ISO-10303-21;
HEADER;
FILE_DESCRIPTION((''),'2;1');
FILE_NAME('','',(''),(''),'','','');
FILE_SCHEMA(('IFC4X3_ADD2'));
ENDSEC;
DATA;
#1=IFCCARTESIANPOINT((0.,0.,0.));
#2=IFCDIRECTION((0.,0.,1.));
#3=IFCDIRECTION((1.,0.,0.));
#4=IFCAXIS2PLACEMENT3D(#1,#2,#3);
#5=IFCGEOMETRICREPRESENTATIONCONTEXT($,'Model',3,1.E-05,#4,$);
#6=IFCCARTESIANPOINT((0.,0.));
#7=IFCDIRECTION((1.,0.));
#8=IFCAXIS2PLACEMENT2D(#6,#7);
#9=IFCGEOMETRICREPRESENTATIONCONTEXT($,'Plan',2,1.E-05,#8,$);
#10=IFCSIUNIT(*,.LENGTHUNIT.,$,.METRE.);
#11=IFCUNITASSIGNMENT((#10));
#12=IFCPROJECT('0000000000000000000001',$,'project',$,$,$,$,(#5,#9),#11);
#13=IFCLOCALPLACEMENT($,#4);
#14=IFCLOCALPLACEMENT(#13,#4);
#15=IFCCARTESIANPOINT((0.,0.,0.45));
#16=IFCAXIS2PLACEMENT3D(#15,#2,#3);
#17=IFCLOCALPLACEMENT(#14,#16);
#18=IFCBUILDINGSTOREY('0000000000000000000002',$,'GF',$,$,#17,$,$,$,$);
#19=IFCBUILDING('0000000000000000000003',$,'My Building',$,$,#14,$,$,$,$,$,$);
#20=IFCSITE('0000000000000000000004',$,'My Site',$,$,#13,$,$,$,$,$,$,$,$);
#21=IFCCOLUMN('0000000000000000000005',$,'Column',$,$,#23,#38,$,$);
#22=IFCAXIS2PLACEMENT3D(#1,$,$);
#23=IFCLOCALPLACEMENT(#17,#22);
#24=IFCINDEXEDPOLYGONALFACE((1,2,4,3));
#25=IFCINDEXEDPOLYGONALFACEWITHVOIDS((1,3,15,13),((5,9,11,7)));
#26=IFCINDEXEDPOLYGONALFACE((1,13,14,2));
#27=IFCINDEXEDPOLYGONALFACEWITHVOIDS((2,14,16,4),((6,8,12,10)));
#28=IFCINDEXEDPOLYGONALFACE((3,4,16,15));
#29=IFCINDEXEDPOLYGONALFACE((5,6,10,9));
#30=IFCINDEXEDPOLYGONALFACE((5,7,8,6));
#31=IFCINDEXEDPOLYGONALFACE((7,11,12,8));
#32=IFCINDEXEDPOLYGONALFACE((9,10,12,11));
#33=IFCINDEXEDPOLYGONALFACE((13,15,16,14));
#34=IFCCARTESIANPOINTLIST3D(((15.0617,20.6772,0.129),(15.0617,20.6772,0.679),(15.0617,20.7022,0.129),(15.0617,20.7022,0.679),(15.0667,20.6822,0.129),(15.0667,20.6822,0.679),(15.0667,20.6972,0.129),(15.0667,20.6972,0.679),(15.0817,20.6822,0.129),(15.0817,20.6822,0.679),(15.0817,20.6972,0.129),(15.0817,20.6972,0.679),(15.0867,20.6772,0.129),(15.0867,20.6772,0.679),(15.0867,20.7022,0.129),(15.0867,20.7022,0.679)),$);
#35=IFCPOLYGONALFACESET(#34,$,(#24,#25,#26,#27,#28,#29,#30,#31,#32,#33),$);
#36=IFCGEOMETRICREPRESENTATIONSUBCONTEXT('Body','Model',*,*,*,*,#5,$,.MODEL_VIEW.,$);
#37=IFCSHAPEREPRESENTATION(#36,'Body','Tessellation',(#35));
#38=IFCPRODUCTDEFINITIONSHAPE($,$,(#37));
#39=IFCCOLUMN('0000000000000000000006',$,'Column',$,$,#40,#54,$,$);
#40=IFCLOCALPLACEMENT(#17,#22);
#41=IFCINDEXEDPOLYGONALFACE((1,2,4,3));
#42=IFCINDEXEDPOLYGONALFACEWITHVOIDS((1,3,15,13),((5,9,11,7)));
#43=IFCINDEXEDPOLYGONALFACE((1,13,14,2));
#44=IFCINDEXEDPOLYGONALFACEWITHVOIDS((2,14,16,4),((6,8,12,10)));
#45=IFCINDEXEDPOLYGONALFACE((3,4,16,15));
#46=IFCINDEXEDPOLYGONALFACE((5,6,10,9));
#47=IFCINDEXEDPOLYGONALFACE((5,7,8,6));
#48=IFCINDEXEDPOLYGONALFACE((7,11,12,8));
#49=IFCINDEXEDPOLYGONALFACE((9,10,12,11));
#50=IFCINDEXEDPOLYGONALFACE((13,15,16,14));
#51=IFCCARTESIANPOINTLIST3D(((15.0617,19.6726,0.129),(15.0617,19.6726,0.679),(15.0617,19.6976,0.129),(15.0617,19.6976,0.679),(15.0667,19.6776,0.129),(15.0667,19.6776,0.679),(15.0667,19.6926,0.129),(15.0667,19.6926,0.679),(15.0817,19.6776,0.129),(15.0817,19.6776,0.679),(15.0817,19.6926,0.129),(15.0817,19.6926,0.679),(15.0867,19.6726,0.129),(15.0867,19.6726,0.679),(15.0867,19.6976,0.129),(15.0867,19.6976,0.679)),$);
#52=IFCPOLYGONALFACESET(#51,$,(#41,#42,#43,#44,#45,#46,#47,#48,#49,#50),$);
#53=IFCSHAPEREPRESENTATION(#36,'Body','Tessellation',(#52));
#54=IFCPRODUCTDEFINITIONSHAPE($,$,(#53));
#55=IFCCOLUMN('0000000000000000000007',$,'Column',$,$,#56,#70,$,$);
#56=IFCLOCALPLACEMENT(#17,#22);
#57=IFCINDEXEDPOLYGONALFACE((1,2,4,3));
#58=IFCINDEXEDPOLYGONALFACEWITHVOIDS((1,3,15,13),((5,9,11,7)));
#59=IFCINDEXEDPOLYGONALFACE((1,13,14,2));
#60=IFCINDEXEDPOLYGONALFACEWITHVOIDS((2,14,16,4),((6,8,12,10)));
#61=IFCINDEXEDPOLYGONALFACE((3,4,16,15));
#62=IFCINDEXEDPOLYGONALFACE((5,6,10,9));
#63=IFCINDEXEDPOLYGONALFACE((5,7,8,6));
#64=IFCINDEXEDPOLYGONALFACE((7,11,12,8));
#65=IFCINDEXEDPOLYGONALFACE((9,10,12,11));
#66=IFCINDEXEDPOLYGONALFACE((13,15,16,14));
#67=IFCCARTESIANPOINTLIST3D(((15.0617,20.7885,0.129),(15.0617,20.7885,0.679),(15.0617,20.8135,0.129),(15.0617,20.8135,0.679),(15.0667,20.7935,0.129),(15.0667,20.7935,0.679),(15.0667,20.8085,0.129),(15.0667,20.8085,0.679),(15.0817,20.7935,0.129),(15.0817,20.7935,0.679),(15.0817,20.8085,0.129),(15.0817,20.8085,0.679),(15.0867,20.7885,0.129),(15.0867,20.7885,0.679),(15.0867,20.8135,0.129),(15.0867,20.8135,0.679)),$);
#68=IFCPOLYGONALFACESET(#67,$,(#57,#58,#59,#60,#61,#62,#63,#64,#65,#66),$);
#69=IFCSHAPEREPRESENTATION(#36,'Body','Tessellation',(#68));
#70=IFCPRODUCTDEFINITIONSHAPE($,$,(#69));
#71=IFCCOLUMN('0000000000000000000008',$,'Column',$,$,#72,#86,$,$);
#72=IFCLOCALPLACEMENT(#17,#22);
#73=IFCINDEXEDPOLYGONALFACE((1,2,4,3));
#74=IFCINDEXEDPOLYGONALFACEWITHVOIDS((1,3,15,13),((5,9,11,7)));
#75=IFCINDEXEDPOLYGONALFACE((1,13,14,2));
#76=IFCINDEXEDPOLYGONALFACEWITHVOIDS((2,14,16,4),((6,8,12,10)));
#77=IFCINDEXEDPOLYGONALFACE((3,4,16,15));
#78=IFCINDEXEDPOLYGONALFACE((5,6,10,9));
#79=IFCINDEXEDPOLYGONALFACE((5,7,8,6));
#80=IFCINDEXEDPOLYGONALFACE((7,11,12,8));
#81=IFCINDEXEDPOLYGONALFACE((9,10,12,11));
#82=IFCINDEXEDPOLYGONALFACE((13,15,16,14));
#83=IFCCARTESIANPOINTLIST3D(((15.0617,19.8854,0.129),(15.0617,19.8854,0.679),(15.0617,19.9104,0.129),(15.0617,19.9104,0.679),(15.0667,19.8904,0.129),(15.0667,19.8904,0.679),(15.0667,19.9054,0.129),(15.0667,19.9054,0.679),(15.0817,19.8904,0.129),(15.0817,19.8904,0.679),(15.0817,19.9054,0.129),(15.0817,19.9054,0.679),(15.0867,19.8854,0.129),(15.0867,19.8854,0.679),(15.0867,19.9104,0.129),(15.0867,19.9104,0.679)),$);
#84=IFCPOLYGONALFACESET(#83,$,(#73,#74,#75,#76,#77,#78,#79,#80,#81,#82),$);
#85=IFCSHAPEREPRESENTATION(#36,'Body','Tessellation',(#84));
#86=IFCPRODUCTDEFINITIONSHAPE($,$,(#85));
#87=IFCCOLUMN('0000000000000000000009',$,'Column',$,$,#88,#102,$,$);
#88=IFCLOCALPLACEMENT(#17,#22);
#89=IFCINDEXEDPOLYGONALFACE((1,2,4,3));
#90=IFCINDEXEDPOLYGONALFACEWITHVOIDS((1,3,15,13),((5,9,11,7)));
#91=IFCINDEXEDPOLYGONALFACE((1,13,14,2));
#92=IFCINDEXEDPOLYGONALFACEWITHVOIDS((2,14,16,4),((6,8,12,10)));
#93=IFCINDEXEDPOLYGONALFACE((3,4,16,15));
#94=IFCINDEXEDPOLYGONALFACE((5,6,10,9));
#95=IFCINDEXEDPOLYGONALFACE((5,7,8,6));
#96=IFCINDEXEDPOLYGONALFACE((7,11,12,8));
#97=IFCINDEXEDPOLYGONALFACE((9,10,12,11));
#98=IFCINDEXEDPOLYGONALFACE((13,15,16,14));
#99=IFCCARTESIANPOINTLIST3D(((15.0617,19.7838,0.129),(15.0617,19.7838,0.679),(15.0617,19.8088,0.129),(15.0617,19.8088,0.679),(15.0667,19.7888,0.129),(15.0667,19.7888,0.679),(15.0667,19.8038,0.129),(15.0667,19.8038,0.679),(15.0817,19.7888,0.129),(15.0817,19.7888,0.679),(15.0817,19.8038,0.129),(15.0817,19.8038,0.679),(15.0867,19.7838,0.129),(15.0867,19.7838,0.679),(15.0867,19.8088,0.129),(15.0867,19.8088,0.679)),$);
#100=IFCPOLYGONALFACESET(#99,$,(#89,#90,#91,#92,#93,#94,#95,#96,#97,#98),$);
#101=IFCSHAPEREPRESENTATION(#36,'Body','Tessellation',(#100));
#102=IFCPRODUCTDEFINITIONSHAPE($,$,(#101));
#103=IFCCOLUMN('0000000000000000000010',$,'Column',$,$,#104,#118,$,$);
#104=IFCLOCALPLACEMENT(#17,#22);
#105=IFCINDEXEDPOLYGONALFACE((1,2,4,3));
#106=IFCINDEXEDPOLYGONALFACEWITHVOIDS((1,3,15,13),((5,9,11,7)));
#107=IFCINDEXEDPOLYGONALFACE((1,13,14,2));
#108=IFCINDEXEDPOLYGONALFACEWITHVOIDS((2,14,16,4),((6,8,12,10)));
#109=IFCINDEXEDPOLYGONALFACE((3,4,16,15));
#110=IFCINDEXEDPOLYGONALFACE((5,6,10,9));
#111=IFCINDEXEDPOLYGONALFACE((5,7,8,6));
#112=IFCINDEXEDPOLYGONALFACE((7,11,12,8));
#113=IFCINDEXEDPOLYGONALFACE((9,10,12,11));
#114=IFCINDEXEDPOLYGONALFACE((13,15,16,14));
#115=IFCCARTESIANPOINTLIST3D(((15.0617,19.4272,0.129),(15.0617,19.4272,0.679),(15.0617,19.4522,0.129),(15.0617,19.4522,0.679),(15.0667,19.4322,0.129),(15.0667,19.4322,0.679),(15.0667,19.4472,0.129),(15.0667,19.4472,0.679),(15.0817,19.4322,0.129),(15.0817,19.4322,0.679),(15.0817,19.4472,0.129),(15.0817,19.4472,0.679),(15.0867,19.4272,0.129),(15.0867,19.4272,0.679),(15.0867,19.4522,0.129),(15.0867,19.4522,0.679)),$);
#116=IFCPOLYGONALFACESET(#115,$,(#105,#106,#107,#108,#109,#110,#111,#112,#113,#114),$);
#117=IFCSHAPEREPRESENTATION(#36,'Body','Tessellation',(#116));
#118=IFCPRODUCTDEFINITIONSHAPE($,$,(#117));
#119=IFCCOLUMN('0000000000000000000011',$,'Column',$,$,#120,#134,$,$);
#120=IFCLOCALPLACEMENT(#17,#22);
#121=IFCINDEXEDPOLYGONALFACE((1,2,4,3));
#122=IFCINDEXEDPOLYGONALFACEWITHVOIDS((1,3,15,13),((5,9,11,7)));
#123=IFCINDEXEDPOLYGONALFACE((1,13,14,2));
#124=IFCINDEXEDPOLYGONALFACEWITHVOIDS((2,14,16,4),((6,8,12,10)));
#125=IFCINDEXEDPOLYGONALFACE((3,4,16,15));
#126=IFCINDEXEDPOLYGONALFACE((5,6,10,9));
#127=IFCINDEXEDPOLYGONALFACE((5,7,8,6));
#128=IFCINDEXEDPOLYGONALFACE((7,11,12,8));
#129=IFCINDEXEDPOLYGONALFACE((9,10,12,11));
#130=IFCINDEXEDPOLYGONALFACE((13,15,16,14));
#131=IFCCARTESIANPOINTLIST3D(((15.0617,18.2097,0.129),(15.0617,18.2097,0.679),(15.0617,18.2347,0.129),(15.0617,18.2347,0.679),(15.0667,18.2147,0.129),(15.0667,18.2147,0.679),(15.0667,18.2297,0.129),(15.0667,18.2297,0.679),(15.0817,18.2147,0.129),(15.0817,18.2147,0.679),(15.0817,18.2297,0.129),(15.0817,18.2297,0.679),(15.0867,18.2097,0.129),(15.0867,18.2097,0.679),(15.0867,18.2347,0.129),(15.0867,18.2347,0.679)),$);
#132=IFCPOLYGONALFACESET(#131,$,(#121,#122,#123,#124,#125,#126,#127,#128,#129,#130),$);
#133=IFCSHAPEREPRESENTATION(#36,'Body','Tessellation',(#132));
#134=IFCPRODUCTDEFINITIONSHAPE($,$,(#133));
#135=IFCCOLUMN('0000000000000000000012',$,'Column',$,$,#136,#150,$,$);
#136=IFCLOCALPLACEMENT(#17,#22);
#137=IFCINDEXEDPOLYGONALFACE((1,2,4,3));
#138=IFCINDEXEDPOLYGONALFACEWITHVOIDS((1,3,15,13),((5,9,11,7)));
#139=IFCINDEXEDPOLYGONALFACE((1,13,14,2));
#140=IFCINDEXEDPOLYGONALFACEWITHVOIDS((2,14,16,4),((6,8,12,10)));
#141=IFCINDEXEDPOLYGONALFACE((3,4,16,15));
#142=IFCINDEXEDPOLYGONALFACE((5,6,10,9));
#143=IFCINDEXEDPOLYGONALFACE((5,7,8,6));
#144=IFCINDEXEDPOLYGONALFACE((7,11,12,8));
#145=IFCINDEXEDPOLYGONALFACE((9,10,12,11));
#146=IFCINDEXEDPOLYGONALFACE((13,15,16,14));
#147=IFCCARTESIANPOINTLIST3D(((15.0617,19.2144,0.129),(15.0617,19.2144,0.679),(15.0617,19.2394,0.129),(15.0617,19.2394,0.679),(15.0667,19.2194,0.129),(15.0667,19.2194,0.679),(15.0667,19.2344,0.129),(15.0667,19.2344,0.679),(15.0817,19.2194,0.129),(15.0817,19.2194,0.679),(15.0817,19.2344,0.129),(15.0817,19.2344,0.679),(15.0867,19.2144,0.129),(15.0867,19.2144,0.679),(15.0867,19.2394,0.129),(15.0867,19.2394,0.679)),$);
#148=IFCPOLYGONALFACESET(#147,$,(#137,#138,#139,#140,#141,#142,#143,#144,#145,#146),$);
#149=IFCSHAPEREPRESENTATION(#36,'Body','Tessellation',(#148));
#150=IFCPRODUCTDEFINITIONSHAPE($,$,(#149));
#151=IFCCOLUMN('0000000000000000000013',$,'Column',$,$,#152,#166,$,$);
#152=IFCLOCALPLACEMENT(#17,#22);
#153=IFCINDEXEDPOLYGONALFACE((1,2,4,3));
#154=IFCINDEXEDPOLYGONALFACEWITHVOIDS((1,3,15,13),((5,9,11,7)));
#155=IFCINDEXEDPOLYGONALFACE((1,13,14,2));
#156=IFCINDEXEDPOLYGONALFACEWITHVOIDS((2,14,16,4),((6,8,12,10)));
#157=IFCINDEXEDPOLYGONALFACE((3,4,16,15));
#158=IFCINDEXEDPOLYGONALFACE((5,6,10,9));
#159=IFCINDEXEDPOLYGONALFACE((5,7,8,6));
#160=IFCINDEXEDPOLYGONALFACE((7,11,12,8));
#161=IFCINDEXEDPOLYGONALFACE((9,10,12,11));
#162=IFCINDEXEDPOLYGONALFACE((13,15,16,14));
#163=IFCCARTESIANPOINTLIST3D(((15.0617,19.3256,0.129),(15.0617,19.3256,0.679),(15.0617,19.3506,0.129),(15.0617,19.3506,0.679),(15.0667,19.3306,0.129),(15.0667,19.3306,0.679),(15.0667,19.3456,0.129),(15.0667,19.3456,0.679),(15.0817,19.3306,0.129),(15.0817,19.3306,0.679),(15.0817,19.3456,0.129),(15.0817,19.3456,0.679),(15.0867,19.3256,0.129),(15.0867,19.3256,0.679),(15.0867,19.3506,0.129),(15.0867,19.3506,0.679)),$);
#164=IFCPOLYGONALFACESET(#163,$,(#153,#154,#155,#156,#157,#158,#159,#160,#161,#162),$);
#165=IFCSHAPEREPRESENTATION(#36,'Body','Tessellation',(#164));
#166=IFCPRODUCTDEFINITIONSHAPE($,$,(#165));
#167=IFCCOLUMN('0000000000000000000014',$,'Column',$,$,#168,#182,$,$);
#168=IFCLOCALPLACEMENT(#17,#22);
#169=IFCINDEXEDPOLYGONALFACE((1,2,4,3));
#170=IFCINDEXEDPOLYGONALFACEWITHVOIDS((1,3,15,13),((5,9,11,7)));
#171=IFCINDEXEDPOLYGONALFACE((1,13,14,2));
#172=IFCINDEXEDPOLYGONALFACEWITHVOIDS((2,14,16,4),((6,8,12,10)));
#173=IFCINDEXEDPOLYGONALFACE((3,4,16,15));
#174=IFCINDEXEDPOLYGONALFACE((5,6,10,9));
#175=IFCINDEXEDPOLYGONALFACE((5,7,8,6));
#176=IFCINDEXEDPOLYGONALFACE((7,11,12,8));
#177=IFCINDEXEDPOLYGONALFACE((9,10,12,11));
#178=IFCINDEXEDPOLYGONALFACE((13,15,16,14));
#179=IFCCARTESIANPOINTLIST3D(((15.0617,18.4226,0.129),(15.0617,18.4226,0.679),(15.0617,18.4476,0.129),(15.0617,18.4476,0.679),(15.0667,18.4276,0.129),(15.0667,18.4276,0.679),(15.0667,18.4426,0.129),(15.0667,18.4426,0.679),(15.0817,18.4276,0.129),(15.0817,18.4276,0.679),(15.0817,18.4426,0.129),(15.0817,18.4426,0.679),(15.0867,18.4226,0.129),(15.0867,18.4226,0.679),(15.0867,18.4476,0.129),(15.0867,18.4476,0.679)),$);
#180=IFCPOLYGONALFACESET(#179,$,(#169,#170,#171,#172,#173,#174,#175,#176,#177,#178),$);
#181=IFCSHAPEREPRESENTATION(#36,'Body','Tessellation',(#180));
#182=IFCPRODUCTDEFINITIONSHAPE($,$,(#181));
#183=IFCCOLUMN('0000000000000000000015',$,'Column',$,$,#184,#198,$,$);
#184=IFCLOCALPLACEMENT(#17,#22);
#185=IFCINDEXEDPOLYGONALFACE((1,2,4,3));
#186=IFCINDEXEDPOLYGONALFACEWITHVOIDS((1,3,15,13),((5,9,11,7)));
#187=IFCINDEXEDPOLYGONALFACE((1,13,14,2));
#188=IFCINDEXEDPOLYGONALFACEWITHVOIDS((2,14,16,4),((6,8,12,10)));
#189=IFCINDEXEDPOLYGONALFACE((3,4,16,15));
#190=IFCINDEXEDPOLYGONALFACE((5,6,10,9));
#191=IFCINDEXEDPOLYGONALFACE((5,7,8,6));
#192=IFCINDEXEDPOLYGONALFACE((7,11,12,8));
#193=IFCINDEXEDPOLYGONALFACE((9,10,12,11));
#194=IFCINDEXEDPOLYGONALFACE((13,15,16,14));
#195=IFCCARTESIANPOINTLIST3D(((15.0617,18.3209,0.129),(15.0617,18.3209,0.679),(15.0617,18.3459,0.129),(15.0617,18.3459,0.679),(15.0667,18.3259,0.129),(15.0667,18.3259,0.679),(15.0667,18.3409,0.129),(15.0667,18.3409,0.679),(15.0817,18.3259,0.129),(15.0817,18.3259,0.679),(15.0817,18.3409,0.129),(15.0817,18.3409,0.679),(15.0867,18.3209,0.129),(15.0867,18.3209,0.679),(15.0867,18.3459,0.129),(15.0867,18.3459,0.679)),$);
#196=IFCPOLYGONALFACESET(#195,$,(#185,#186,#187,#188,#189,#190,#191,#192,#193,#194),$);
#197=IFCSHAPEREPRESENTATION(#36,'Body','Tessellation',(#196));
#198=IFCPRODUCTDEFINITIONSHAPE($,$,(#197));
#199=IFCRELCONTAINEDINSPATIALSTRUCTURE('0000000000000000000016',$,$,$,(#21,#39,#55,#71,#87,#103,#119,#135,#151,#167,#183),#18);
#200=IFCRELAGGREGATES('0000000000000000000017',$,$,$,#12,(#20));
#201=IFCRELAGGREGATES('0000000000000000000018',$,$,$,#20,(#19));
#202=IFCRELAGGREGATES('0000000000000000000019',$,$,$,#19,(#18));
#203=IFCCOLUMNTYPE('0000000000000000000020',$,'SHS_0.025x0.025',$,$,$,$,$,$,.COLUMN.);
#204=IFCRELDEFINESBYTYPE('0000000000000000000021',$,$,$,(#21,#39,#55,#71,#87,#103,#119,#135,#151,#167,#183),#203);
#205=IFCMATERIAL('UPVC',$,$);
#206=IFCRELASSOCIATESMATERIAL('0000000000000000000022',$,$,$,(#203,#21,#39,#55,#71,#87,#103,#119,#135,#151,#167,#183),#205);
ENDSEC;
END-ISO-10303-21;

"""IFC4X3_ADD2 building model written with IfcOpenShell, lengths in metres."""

from ifc_helpers import new_model, si_unit, frame, origin_with_axes, origin_2d_with_axis, place, context, subcontext, project, spatial, hollow_rectangle, extrude, material, material_profile, profile_set, profile_usage, type_object, element, save


model = new_model("IFC4X3_ADD2")

# Units and contexts
model_context = context("Model", 3, precision=1e-05, world=origin_with_axes())
plan_context = context("Plan", 2, precision=1e-05, world=origin_2d_with_axis())
body_context_1 = subcontext(model_context, "Body", "Model", "MODEL_VIEW")
ifc_project = project(units=[si_unit("LENGTHUNIT", "METRE")], contexts=[model_context, plan_context])

# Site, building, storey
site_placement = place(None, origin_with_axes())
site = spatial("IfcSite", under=ifc_project, at=site_placement, Name="My Site")
building_placement = place(site_placement, origin_with_axes())
building = spatial("IfcBuilding", under=site, at=building_placement, Name="My Building")
storey_placement = place(building_placement, frame((0.0, 0.0, 0.45), z_axis=(0.0, 0.0, 1.0), x_axis=(1.0, 0.0, 0.0)))
storey = spatial("IfcBuildingStorey", under=building, at=storey_placement, Name="GF")

# Columns
ifc_material_1 = material(Name="UPVC")
ifc_material_profile_1 = material_profile(ifc_material_1, hollow_rectangle(XDim=0.025, YDim=0.025, WallThickness=0.005))
ifc_profile_set_1 = profile_set([ifc_material_profile_1])
ifc_profile_usage_1 = profile_usage(ifc_profile_set_1)
column_type_1 = type_object("IfcColumnType", Name="SHS_0.025x0.025", PredefinedType="COLUMN", material=ifc_profile_set_1)
column_1_placement = place(storey_placement, frame((15.0742, 20.6897, 0.129), z_axis=(0.0, 0.0, 1.0), x_axis=(0.0, -1.0, 0.0)))
element("IfcColumn", 1, at=column_1_placement, inside=storey, type_object=column_type_1, material=ifc_profile_usage_1, Name="Column", context=body_context_1, shape_type="SweptSolid", body=[
    extrude(hollow_rectangle(XDim=0.025, YDim=0.025, WallThickness=0.005), origin_with_axes(), (0.0, 0.0, 1.0), 0.55),
])
ifc_profile_usage_2 = profile_usage(ifc_profile_set_1)
column_2_placement = place(storey_placement, frame((15.0742, 19.6851, 0.129), z_axis=(0.0, 0.0, 1.0), x_axis=(0.0, -1.0, 0.0)))
element("IfcColumn", 2, at=column_2_placement, inside=storey, type_object=column_type_1, material=ifc_profile_usage_2, Name="Column", context=body_context_1, shape_type="SweptSolid", body=[
    extrude(hollow_rectangle(XDim=0.025, YDim=0.025, WallThickness=0.005), origin_with_axes(), (0.0, 0.0, 1.0), 0.55),
])
ifc_profile_usage_3 = profile_usage(ifc_profile_set_1)
column_3_placement = place(storey_placement, frame((15.0742, 20.801, 0.129), z_axis=(0.0, 0.0, 1.0), x_axis=(0.0, -1.0, 0.0)))
element("IfcColumn", 3, at=column_3_placement, inside=storey, type_object=column_type_1, material=ifc_profile_usage_3, Name="Column", context=body_context_1, shape_type="SweptSolid", body=[
    extrude(hollow_rectangle(XDim=0.025, YDim=0.025, WallThickness=0.005), origin_with_axes(), (0.0, 0.0, 1.0), 0.55),
])
ifc_profile_usage_4 = profile_usage(ifc_profile_set_1)
column_4_placement = place(storey_placement, frame((15.0742, 19.8979, 0.129), z_axis=(0.0, 0.0, 1.0), x_axis=(0.0, -1.0, 0.0)))
element("IfcColumn", 4, at=column_4_placement, inside=storey, type_object=column_type_1, material=ifc_profile_usage_4, Name="Column", context=body_context_1, shape_type="SweptSolid", body=[
    extrude(hollow_rectangle(XDim=0.025, YDim=0.025, WallThickness=0.005), origin_with_axes(), (0.0, 0.0, 1.0), 0.55),
])
ifc_profile_usage_5 = profile_usage(ifc_profile_set_1)
column_5_placement = place(storey_placement, frame((15.0742, 19.7963, 0.129), z_axis=(0.0, 0.0, 1.0), x_axis=(0.0, -1.0, 0.0)))
element("IfcColumn", 5, at=column_5_placement, inside=storey, type_object=column_type_1, material=ifc_profile_usage_5, Name="Column", context=body_context_1, shape_type="SweptSolid", body=[
    extrude(hollow_rectangle(XDim=0.025, YDim=0.025, WallThickness=0.005), origin_with_axes(), (0.0, 0.0, 1.0), 0.55),
])
ifc_profile_usage_6 = profile_usage(ifc_profile_set_1)
column_6_placement = place(storey_placement, frame((15.0742, 19.4397, 0.129), z_axis=(0.0, 0.0, 1.0), x_axis=(0.0, -1.0, 0.0)))
element("IfcColumn", 6, at=column_6_placement, inside=storey, type_object=column_type_1, material=ifc_profile_usage_6, Name="Column", context=body_context_1, shape_type="SweptSolid", body=[
    extrude(hollow_rectangle(XDim=0.025, YDim=0.025, WallThickness=0.005), origin_with_axes(), (0.0, 0.0, 1.0), 0.55),
])
ifc_profile_usage_7 = profile_usage(ifc_profile_set_1)
column_7_placement = place(storey_placement, frame((15.0742, 18.2222, 0.129), z_axis=(0.0, 0.0, 1.0), x_axis=(0.0, -1.0, 0.0)))
element("IfcColumn", 7, at=column_7_placement, inside=storey, type_object=column_type_1, material=ifc_profile_usage_7, Name="Column", context=body_context_1, shape_type="SweptSolid", body=[
    extrude(hollow_rectangle(XDim=0.025, YDim=0.025, WallThickness=0.005), origin_with_axes(), (0.0, 0.0, 1.0), 0.55),
])
ifc_profile_usage_8 = profile_usage(ifc_profile_set_1)
column_8_placement = place(storey_placement, frame((15.0742, 19.2269, 0.129), z_axis=(0.0, 0.0, 1.0), x_axis=(0.0, -1.0, 0.0)))
element("IfcColumn", 8, at=column_8_placement, inside=storey, type_object=column_type_1, material=ifc_profile_usage_8, Name="Column", context=body_context_1, shape_type="SweptSolid", body=[
    extrude(hollow_rectangle(XDim=0.025, YDim=0.025, WallThickness=0.005), origin_with_axes(), (0.0, 0.0, 1.0), 0.55),
])
ifc_profile_usage_9 = profile_usage(ifc_profile_set_1)
column_9_placement = place(storey_placement, frame((15.0742, 19.3381, 0.129), z_axis=(0.0, 0.0, 1.0), x_axis=(0.0, -1.0, 0.0)))
element("IfcColumn", 9, at=column_9_placement, inside=storey, type_object=column_type_1, material=ifc_profile_usage_9, Name="Column", context=body_context_1, shape_type="SweptSolid", body=[
    extrude(hollow_rectangle(XDim=0.025, YDim=0.025, WallThickness=0.005), origin_with_axes(), (0.0, 0.0, 1.0), 0.55),
])
ifc_profile_usage_10 = profile_usage(ifc_profile_set_1)
column_10_placement = place(storey_placement, frame((15.0742, 18.4351, 0.129), z_axis=(0.0, 0.0, 1.0), x_axis=(0.0, -1.0, 0.0)))
element("IfcColumn", 10, at=column_10_placement, inside=storey, type_object=column_type_1, material=ifc_profile_usage_10, Name="Column", context=body_context_1, shape_type="SweptSolid", body=[
    extrude(hollow_rectangle(XDim=0.025, YDim=0.025, WallThickness=0.005), origin_with_axes(), (0.0, 0.0, 1.0), 0.55),
])
ifc_profile_usage_11 = profile_usage(ifc_profile_set_1)
column_11_placement = place(storey_placement, frame((15.0742, 18.3334, 0.129), z_axis=(0.0, 0.0, 1.0), x_axis=(0.0, -1.0, 0.0)))
element("IfcColumn", 11, at=column_11_placement, inside=storey, type_object=column_type_1, material=ifc_profile_usage_11, Name="Column", context=body_context_1, shape_type="SweptSolid", body=[
    extrude(hollow_rectangle(XDim=0.025, YDim=0.025, WallThickness=0.005), origin_with_axes(), (0.0, 0.0, 1.0), 0.55),
])

save(model, "model.ifc")
